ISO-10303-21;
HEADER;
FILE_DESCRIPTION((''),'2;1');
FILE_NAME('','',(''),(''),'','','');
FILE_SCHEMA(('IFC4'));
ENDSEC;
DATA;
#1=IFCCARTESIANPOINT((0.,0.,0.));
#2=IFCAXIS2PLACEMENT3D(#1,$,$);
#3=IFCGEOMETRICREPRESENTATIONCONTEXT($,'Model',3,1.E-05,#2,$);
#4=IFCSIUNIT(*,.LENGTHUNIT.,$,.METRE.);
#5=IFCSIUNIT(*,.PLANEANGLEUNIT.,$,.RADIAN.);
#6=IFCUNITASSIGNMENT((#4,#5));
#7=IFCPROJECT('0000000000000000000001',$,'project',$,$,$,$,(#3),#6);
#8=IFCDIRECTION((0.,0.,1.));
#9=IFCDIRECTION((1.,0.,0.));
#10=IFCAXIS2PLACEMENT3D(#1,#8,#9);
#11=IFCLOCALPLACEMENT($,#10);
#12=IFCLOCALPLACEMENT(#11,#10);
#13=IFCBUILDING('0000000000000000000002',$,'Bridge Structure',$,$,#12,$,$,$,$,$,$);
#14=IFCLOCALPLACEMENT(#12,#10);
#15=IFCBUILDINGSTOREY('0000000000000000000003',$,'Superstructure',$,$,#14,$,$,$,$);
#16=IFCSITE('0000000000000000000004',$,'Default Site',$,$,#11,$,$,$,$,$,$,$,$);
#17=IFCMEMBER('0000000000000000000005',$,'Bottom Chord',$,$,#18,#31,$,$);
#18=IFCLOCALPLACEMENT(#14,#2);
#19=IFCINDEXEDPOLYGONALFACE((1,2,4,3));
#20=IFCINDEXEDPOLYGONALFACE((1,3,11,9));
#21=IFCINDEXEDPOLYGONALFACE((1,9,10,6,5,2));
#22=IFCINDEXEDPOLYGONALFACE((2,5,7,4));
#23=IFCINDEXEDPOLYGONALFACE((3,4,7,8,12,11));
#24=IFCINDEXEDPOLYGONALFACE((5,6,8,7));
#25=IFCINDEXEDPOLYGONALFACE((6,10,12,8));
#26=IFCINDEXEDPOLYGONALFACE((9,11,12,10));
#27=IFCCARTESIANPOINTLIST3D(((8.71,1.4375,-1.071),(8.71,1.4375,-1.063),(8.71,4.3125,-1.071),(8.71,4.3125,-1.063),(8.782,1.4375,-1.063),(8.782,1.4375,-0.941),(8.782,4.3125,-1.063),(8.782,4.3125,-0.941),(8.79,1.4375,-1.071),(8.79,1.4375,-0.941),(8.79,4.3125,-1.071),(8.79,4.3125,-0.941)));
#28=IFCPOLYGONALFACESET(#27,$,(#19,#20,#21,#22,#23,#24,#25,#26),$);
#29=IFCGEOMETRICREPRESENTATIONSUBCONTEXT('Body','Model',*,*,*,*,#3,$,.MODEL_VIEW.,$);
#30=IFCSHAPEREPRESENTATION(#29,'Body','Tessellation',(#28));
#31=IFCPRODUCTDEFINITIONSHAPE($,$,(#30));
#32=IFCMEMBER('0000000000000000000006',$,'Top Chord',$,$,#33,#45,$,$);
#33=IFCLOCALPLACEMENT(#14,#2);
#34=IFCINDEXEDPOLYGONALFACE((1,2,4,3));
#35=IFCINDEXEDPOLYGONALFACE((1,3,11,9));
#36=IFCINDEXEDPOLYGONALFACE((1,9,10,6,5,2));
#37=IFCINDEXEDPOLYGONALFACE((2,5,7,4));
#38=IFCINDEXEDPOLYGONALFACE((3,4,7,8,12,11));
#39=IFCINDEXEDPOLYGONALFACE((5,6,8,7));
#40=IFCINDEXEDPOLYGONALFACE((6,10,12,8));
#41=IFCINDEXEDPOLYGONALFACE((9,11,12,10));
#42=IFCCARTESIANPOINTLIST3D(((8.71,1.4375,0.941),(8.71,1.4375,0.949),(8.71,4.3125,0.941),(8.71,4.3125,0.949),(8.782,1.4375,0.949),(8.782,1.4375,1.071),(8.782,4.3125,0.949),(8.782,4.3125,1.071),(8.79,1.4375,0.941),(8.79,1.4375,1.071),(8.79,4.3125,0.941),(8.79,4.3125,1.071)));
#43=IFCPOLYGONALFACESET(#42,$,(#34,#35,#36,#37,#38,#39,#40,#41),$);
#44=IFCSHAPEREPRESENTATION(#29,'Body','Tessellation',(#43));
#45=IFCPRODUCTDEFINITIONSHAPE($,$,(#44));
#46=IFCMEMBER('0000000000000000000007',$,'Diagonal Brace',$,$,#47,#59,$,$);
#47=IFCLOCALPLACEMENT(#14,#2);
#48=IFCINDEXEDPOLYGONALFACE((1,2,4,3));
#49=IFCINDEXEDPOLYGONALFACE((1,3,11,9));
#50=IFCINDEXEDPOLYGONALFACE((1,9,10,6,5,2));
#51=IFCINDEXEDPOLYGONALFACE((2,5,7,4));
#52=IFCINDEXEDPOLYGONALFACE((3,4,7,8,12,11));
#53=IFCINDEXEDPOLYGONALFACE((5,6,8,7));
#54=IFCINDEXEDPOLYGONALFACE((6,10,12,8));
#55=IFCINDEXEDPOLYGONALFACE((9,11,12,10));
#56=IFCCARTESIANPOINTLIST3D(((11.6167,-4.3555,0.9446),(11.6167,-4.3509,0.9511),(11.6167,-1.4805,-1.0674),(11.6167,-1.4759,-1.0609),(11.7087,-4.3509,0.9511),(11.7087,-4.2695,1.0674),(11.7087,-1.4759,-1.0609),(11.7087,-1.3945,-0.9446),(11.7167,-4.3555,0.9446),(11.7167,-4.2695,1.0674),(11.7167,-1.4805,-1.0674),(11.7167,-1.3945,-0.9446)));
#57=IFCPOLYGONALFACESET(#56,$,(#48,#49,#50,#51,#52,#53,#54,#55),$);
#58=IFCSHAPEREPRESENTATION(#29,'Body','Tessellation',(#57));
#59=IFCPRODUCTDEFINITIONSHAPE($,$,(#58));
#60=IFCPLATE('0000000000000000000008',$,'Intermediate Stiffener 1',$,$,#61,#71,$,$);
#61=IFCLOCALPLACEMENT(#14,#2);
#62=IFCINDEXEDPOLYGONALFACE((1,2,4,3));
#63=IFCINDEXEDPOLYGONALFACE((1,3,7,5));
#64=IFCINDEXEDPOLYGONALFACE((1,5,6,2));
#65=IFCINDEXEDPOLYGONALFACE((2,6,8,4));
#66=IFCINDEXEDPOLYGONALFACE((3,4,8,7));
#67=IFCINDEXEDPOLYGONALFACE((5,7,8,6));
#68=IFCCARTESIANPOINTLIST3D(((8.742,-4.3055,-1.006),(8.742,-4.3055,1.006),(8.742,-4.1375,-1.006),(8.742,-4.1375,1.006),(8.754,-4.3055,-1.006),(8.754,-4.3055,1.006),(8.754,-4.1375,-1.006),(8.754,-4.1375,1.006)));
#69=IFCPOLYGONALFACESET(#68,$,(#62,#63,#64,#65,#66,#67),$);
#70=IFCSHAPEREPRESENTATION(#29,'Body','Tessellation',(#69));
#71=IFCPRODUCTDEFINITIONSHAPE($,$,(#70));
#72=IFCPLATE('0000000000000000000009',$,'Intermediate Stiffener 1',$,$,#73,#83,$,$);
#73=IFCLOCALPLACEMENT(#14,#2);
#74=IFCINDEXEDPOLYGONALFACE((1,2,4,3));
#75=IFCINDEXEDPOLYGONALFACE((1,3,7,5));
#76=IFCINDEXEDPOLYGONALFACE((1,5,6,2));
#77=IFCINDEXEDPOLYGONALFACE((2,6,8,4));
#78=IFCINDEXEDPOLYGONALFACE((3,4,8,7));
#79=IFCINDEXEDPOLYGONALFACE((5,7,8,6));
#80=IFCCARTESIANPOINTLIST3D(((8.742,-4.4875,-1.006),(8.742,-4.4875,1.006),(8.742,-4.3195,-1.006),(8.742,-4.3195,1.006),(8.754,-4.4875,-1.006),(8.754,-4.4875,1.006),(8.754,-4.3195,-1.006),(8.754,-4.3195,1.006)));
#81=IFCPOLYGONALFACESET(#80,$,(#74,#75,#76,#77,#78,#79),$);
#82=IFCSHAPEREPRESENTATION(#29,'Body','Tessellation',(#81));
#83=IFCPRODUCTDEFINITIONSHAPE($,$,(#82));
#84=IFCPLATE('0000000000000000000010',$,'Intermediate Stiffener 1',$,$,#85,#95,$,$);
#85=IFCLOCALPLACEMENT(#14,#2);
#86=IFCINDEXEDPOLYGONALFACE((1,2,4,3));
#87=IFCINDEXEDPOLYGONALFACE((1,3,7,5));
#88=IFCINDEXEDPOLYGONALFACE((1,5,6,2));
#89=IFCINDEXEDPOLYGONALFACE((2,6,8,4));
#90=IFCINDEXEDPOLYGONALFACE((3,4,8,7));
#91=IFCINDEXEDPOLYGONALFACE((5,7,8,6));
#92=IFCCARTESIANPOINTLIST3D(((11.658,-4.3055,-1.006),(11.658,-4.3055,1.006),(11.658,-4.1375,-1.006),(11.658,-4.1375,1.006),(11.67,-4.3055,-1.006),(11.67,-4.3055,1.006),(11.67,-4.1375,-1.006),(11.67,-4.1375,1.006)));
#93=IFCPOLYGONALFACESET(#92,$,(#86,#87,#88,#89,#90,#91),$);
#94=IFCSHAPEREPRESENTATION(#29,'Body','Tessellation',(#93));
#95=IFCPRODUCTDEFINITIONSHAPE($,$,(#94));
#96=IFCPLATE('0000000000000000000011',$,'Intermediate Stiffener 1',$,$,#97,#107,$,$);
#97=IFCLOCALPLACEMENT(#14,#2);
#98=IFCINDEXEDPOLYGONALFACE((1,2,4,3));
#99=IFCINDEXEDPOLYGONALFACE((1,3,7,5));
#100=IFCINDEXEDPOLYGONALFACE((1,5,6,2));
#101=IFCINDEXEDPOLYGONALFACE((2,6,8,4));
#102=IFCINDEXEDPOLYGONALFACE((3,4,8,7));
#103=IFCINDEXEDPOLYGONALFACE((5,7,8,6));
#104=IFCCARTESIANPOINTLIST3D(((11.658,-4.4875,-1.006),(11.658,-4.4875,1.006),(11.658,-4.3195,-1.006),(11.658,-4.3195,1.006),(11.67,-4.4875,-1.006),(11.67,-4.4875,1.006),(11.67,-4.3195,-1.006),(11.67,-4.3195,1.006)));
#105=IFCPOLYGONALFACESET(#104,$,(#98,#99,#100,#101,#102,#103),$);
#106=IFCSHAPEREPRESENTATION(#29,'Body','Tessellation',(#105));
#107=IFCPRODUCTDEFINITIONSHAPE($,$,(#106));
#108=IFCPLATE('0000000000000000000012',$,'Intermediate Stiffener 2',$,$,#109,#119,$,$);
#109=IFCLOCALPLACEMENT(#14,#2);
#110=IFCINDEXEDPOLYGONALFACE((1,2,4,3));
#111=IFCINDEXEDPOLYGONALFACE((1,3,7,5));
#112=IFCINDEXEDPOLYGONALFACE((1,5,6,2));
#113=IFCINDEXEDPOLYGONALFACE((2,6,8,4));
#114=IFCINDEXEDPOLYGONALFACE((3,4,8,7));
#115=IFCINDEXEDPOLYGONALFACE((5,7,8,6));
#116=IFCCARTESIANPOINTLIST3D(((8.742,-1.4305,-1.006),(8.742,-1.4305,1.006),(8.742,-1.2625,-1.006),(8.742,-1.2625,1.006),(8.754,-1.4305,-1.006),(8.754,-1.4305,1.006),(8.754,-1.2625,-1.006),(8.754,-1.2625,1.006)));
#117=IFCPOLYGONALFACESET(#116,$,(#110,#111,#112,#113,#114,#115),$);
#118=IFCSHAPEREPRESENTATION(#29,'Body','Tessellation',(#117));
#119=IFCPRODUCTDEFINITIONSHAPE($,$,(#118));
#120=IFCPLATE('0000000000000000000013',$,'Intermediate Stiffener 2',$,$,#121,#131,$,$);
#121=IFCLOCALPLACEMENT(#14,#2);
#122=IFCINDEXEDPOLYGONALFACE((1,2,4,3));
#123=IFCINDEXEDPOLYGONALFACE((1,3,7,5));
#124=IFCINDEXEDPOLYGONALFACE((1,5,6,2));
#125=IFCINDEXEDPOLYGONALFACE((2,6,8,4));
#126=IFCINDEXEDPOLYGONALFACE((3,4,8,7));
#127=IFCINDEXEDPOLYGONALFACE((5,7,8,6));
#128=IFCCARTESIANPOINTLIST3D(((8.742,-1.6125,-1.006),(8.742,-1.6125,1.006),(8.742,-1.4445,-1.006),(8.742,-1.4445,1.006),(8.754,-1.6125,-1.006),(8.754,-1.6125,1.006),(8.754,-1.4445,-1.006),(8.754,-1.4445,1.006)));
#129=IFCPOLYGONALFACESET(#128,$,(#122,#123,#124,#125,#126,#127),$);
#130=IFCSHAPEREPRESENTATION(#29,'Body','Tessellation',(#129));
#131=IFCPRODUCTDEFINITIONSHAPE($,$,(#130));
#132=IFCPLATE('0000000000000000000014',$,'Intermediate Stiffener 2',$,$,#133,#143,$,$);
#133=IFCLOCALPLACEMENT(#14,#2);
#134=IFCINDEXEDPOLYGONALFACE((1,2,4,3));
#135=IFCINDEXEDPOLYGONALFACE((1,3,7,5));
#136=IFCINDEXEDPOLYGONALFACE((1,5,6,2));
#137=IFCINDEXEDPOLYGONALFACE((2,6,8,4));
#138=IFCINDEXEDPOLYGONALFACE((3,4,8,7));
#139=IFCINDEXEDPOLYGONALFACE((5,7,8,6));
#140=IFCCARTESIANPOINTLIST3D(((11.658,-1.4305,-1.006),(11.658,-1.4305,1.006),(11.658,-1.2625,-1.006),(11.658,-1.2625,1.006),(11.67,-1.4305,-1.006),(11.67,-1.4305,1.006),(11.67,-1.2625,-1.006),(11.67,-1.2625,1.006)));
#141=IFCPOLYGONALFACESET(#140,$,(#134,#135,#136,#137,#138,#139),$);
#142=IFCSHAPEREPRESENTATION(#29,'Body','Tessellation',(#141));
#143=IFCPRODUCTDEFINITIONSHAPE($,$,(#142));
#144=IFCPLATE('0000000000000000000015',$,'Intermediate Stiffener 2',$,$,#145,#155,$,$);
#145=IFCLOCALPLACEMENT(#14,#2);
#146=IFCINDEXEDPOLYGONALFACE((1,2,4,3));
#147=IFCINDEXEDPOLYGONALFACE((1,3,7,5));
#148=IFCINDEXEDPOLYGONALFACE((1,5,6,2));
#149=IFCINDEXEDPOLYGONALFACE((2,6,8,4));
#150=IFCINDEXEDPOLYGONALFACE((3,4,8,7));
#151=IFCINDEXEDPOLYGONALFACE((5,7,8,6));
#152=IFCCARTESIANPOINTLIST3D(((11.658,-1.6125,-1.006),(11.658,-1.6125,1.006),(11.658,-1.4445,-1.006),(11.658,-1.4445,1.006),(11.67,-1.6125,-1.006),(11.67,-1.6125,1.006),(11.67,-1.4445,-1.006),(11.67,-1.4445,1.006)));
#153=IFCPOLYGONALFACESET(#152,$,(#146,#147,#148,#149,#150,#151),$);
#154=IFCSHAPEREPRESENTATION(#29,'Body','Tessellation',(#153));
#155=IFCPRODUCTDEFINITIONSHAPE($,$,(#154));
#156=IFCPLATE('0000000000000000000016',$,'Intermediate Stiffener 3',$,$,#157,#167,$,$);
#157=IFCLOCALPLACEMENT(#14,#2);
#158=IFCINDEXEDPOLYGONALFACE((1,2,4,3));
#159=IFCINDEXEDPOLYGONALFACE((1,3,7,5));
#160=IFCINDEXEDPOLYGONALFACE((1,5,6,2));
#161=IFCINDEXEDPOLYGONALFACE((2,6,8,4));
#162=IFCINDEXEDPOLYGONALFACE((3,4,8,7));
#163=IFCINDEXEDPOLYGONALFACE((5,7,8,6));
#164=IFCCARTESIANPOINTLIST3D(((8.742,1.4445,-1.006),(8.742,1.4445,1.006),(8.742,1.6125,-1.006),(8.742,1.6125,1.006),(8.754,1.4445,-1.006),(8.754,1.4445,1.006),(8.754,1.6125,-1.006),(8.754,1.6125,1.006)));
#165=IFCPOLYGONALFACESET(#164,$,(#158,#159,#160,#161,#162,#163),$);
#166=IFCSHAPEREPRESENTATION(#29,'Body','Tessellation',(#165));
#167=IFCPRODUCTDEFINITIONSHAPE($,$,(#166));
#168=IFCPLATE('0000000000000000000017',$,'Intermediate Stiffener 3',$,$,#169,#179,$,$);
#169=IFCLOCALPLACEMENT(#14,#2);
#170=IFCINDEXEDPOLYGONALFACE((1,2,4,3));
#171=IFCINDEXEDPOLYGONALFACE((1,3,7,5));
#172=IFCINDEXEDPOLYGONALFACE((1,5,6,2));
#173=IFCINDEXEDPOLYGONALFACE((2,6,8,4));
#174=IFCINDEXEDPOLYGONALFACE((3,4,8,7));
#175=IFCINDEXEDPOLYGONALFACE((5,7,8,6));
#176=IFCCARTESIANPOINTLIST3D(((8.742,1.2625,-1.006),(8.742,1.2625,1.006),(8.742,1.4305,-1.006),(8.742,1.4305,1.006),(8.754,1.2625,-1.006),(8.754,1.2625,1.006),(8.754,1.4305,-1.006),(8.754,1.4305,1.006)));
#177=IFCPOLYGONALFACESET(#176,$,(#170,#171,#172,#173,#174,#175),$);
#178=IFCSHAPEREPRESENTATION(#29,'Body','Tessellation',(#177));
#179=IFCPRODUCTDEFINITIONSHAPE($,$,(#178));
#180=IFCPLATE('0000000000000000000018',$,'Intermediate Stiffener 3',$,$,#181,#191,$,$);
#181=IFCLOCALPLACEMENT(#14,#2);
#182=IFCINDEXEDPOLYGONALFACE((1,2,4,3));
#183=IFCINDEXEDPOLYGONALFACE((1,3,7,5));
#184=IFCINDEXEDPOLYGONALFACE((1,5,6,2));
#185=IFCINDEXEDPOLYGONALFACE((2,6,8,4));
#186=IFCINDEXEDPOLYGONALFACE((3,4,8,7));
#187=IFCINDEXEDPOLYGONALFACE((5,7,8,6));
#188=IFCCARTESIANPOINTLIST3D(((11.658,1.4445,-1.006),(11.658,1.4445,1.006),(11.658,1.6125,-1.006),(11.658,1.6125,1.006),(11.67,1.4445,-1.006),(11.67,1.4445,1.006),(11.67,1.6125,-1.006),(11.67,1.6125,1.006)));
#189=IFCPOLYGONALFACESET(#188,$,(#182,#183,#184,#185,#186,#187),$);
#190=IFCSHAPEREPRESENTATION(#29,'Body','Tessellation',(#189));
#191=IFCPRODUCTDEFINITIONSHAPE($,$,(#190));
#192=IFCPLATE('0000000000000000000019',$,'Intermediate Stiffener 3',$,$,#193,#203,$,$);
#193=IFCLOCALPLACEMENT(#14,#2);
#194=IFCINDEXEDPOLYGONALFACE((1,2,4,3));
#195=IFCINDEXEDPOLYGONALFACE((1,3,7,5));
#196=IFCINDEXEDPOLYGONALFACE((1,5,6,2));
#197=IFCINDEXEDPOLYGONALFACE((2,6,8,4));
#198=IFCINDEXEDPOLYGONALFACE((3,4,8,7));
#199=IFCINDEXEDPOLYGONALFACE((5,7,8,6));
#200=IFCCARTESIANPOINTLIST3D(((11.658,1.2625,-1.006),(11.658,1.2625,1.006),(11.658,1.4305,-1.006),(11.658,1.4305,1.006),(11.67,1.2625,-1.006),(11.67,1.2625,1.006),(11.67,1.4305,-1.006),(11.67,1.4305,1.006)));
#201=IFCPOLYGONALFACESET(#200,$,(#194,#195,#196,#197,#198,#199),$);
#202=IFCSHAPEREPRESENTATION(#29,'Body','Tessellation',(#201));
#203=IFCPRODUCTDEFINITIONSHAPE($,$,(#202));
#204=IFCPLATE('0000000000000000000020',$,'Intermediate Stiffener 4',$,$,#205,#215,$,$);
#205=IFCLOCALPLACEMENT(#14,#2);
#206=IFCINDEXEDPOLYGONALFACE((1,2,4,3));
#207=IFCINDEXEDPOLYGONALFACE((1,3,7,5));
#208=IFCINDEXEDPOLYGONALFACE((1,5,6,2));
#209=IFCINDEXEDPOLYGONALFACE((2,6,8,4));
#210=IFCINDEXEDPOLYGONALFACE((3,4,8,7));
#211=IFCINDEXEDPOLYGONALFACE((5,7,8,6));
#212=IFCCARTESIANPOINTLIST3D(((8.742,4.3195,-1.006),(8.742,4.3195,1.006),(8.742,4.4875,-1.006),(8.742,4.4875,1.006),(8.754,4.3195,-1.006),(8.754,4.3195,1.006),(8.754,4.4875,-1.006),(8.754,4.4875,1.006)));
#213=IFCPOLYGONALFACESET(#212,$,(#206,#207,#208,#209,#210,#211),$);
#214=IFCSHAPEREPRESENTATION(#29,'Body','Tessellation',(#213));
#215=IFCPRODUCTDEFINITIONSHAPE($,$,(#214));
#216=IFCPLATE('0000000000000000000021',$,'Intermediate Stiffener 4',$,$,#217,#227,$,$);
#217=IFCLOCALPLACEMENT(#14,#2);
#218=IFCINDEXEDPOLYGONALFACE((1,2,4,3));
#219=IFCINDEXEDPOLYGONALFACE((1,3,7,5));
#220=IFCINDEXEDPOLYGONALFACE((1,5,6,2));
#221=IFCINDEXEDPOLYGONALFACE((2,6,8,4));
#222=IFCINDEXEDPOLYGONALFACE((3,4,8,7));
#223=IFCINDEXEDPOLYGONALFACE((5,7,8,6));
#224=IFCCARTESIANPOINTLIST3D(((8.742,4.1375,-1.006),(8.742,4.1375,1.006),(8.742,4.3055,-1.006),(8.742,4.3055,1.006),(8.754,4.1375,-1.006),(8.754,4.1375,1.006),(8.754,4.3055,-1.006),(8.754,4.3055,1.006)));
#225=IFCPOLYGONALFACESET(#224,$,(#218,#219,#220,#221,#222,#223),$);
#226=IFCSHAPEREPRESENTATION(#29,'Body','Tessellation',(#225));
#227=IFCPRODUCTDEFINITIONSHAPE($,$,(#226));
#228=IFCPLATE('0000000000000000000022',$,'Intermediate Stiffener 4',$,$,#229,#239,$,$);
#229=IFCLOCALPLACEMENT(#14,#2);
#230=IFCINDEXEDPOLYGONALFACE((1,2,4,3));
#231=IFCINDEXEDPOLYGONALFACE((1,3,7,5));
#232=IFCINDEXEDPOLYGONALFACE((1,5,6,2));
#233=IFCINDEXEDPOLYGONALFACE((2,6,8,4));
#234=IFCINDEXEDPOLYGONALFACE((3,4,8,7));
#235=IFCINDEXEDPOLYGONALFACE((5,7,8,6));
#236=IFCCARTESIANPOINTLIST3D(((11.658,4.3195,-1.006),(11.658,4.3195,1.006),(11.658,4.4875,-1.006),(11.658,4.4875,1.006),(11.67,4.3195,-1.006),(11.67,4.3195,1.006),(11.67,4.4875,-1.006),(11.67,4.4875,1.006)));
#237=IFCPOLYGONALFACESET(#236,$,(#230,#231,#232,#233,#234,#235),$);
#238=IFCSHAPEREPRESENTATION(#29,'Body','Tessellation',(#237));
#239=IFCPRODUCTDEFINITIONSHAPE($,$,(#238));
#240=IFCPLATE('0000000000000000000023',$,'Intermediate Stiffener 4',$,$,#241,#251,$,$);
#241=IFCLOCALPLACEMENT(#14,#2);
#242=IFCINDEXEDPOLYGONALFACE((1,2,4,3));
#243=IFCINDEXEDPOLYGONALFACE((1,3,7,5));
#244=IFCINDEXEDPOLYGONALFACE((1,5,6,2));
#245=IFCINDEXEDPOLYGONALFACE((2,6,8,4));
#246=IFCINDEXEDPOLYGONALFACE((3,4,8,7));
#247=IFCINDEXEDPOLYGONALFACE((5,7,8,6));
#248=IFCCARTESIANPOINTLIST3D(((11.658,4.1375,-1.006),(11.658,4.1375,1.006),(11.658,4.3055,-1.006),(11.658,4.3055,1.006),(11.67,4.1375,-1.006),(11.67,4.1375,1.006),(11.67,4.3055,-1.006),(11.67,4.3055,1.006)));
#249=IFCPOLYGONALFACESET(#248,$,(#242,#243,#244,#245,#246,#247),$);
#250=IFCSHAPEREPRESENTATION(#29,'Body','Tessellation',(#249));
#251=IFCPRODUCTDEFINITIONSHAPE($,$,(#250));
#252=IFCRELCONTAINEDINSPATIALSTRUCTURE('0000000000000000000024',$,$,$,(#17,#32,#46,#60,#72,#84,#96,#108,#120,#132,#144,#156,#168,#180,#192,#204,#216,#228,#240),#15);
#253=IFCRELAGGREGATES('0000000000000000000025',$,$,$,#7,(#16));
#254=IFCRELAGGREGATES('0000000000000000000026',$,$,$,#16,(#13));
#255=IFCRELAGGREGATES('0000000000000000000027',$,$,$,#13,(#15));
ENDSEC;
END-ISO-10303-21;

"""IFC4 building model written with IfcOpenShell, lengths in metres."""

from ifc_helpers import new_model, si_unit, frame, origin, origin_with_axes, origin_2d_with_axis, place, context, subcontext, project, spatial, rectangle, l_section, extrude, element, save


model = new_model("IFC4")

# Units and contexts
model_context = context("Model", 3, precision=1e-05, world=origin())
body_context = subcontext(model_context, "Body", "Model", "MODEL_VIEW")
ifc_project = project(units=[si_unit("LENGTHUNIT", "METRE"), si_unit("PLANEANGLEUNIT", "RADIAN")], contexts=[model_context])

# Site, building, storey
site_placement = place(None, origin_with_axes())
site = spatial("IfcSite", under=ifc_project, at=site_placement, Name="Default Site")
building_placement = place(site_placement, origin_with_axes())
building = spatial("IfcBuilding", under=site, at=building_placement, Name="Bridge Structure")
storey_placement = place(building_placement, origin_with_axes())
storey = spatial("IfcBuildingStorey", under=building, at=storey_placement, Name="Superstructure")

# Members
for number, where, z_axis, x_axis, name in (
    (1, (8.75, 1.4375, -1.006), (0.0, 1.0, 0.0), (-1.0, 0.0, 0.0), "Bottom Chord"),
    (2, (8.75, 1.4375, 1.006), (0.0, 1.0, 0.0), (-1.0, 0.0, 0.0), "Top Chord"),
):
    element("IfcMember", number, at=place(storey_placement, frame(where, z_axis=z_axis, x_axis=x_axis)), inside=storey, Name=name, context=body_context, shape_type="SweptSolid", body=[
        extrude(l_section(Depth=0.13, Width=0.08, Thickness=0.008, at=origin_2d_with_axis()), origin_with_axes(), (0.0, 0.0, 1.0), 2.875),
    ])
member_1_placement = place(storey_placement, frame((11.6667, -4.3125, 1.006), z_axis=(0.0, 0.819299, -0.573367), x_axis=(-1.0, 0.0, 0.0)))
element("IfcMember", 3, at=member_1_placement, inside=storey, Name="Diagonal Brace", context=body_context, shape_type="SweptSolid", body=[
    extrude(l_section(Depth=0.15, Width=0.1, Thickness=0.008, at=origin_2d_with_axis()), origin_with_axes(), (0.0, 0.0, 1.0), 3.5091),
])

# Plates
for number, where, z_axis, x_axis, name in (
    (4, (8.748, -4.2215, -1.006), (0.0, 0.0, 1.0), (1.0, 0.0, 0.0), "Intermediate Stiffener 1"),
    (5, (8.748, -4.4035, -1.006), (0.0, 0.0, 1.0), (1.0, 0.0, 0.0), "Intermediate Stiffener 1"),
    (6, (11.664, -4.2215, -1.006), (0.0, 0.0, 1.0), (1.0, 0.0, 0.0), "Intermediate Stiffener 1"),
    (7, (11.664, -4.4035, -1.006), (0.0, 0.0, 1.0), (1.0, 0.0, 0.0), "Intermediate Stiffener 1"),
    (8, (8.748, -1.3465, -1.006), (0.0, 0.0, 1.0), (1.0, 0.0, 0.0), "Intermediate Stiffener 2"),
    (9, (8.748, -1.5285, -1.006), (0.0, 0.0, 1.0), (1.0, 0.0, 0.0), "Intermediate Stiffener 2"),
    (10, (11.664, -1.3465, -1.006), (0.0, 0.0, 1.0), (1.0, 0.0, 0.0), "Intermediate Stiffener 2"),
    (11, (11.664, -1.5285, -1.006), (0.0, 0.0, 1.0), (1.0, 0.0, 0.0), "Intermediate Stiffener 2"),
    (12, (8.748, 1.5285, -1.006), (0.0, 0.0, 1.0), (1.0, 0.0, 0.0), "Intermediate Stiffener 3"),
    (13, (8.748, 1.3465, -1.006), (0.0, 0.0, 1.0), (1.0, 0.0, 0.0), "Intermediate Stiffener 3"),
    (14, (11.664, 1.5285, -1.006), (0.0, 0.0, 1.0), (1.0, 0.0, 0.0), "Intermediate Stiffener 3"),
    (15, (11.664, 1.3465, -1.006), (0.0, 0.0, 1.0), (1.0, 0.0, 0.0), "Intermediate Stiffener 3"),
    (16, (8.748, 4.4035, -1.006), (0.0, 0.0, 1.0), (1.0, 0.0, 0.0), "Intermediate Stiffener 4"),
    (17, (8.748, 4.2215, -1.006), (0.0, 0.0, 1.0), (1.0, 0.0, 0.0), "Intermediate Stiffener 4"),
    (18, (11.664, 4.4035, -1.006), (0.0, 0.0, 1.0), (1.0, 0.0, 0.0), "Intermediate Stiffener 4"),
    (19, (11.664, 4.2215, -1.006), (0.0, 0.0, 1.0), (1.0, 0.0, 0.0), "Intermediate Stiffener 4"),
):
    element("IfcPlate", number, at=place(storey_placement, frame(where, z_axis=z_axis, x_axis=x_axis)), inside=storey, Name=name, context=body_context, shape_type="SweptSolid", body=[
        extrude(rectangle(XDim=0.012, YDim=0.168, at=origin_2d_with_axis()), origin_with_axes(), (0.0, 0.0, 1.0), 2.012),
    ])

save(model, "model.ifc")
